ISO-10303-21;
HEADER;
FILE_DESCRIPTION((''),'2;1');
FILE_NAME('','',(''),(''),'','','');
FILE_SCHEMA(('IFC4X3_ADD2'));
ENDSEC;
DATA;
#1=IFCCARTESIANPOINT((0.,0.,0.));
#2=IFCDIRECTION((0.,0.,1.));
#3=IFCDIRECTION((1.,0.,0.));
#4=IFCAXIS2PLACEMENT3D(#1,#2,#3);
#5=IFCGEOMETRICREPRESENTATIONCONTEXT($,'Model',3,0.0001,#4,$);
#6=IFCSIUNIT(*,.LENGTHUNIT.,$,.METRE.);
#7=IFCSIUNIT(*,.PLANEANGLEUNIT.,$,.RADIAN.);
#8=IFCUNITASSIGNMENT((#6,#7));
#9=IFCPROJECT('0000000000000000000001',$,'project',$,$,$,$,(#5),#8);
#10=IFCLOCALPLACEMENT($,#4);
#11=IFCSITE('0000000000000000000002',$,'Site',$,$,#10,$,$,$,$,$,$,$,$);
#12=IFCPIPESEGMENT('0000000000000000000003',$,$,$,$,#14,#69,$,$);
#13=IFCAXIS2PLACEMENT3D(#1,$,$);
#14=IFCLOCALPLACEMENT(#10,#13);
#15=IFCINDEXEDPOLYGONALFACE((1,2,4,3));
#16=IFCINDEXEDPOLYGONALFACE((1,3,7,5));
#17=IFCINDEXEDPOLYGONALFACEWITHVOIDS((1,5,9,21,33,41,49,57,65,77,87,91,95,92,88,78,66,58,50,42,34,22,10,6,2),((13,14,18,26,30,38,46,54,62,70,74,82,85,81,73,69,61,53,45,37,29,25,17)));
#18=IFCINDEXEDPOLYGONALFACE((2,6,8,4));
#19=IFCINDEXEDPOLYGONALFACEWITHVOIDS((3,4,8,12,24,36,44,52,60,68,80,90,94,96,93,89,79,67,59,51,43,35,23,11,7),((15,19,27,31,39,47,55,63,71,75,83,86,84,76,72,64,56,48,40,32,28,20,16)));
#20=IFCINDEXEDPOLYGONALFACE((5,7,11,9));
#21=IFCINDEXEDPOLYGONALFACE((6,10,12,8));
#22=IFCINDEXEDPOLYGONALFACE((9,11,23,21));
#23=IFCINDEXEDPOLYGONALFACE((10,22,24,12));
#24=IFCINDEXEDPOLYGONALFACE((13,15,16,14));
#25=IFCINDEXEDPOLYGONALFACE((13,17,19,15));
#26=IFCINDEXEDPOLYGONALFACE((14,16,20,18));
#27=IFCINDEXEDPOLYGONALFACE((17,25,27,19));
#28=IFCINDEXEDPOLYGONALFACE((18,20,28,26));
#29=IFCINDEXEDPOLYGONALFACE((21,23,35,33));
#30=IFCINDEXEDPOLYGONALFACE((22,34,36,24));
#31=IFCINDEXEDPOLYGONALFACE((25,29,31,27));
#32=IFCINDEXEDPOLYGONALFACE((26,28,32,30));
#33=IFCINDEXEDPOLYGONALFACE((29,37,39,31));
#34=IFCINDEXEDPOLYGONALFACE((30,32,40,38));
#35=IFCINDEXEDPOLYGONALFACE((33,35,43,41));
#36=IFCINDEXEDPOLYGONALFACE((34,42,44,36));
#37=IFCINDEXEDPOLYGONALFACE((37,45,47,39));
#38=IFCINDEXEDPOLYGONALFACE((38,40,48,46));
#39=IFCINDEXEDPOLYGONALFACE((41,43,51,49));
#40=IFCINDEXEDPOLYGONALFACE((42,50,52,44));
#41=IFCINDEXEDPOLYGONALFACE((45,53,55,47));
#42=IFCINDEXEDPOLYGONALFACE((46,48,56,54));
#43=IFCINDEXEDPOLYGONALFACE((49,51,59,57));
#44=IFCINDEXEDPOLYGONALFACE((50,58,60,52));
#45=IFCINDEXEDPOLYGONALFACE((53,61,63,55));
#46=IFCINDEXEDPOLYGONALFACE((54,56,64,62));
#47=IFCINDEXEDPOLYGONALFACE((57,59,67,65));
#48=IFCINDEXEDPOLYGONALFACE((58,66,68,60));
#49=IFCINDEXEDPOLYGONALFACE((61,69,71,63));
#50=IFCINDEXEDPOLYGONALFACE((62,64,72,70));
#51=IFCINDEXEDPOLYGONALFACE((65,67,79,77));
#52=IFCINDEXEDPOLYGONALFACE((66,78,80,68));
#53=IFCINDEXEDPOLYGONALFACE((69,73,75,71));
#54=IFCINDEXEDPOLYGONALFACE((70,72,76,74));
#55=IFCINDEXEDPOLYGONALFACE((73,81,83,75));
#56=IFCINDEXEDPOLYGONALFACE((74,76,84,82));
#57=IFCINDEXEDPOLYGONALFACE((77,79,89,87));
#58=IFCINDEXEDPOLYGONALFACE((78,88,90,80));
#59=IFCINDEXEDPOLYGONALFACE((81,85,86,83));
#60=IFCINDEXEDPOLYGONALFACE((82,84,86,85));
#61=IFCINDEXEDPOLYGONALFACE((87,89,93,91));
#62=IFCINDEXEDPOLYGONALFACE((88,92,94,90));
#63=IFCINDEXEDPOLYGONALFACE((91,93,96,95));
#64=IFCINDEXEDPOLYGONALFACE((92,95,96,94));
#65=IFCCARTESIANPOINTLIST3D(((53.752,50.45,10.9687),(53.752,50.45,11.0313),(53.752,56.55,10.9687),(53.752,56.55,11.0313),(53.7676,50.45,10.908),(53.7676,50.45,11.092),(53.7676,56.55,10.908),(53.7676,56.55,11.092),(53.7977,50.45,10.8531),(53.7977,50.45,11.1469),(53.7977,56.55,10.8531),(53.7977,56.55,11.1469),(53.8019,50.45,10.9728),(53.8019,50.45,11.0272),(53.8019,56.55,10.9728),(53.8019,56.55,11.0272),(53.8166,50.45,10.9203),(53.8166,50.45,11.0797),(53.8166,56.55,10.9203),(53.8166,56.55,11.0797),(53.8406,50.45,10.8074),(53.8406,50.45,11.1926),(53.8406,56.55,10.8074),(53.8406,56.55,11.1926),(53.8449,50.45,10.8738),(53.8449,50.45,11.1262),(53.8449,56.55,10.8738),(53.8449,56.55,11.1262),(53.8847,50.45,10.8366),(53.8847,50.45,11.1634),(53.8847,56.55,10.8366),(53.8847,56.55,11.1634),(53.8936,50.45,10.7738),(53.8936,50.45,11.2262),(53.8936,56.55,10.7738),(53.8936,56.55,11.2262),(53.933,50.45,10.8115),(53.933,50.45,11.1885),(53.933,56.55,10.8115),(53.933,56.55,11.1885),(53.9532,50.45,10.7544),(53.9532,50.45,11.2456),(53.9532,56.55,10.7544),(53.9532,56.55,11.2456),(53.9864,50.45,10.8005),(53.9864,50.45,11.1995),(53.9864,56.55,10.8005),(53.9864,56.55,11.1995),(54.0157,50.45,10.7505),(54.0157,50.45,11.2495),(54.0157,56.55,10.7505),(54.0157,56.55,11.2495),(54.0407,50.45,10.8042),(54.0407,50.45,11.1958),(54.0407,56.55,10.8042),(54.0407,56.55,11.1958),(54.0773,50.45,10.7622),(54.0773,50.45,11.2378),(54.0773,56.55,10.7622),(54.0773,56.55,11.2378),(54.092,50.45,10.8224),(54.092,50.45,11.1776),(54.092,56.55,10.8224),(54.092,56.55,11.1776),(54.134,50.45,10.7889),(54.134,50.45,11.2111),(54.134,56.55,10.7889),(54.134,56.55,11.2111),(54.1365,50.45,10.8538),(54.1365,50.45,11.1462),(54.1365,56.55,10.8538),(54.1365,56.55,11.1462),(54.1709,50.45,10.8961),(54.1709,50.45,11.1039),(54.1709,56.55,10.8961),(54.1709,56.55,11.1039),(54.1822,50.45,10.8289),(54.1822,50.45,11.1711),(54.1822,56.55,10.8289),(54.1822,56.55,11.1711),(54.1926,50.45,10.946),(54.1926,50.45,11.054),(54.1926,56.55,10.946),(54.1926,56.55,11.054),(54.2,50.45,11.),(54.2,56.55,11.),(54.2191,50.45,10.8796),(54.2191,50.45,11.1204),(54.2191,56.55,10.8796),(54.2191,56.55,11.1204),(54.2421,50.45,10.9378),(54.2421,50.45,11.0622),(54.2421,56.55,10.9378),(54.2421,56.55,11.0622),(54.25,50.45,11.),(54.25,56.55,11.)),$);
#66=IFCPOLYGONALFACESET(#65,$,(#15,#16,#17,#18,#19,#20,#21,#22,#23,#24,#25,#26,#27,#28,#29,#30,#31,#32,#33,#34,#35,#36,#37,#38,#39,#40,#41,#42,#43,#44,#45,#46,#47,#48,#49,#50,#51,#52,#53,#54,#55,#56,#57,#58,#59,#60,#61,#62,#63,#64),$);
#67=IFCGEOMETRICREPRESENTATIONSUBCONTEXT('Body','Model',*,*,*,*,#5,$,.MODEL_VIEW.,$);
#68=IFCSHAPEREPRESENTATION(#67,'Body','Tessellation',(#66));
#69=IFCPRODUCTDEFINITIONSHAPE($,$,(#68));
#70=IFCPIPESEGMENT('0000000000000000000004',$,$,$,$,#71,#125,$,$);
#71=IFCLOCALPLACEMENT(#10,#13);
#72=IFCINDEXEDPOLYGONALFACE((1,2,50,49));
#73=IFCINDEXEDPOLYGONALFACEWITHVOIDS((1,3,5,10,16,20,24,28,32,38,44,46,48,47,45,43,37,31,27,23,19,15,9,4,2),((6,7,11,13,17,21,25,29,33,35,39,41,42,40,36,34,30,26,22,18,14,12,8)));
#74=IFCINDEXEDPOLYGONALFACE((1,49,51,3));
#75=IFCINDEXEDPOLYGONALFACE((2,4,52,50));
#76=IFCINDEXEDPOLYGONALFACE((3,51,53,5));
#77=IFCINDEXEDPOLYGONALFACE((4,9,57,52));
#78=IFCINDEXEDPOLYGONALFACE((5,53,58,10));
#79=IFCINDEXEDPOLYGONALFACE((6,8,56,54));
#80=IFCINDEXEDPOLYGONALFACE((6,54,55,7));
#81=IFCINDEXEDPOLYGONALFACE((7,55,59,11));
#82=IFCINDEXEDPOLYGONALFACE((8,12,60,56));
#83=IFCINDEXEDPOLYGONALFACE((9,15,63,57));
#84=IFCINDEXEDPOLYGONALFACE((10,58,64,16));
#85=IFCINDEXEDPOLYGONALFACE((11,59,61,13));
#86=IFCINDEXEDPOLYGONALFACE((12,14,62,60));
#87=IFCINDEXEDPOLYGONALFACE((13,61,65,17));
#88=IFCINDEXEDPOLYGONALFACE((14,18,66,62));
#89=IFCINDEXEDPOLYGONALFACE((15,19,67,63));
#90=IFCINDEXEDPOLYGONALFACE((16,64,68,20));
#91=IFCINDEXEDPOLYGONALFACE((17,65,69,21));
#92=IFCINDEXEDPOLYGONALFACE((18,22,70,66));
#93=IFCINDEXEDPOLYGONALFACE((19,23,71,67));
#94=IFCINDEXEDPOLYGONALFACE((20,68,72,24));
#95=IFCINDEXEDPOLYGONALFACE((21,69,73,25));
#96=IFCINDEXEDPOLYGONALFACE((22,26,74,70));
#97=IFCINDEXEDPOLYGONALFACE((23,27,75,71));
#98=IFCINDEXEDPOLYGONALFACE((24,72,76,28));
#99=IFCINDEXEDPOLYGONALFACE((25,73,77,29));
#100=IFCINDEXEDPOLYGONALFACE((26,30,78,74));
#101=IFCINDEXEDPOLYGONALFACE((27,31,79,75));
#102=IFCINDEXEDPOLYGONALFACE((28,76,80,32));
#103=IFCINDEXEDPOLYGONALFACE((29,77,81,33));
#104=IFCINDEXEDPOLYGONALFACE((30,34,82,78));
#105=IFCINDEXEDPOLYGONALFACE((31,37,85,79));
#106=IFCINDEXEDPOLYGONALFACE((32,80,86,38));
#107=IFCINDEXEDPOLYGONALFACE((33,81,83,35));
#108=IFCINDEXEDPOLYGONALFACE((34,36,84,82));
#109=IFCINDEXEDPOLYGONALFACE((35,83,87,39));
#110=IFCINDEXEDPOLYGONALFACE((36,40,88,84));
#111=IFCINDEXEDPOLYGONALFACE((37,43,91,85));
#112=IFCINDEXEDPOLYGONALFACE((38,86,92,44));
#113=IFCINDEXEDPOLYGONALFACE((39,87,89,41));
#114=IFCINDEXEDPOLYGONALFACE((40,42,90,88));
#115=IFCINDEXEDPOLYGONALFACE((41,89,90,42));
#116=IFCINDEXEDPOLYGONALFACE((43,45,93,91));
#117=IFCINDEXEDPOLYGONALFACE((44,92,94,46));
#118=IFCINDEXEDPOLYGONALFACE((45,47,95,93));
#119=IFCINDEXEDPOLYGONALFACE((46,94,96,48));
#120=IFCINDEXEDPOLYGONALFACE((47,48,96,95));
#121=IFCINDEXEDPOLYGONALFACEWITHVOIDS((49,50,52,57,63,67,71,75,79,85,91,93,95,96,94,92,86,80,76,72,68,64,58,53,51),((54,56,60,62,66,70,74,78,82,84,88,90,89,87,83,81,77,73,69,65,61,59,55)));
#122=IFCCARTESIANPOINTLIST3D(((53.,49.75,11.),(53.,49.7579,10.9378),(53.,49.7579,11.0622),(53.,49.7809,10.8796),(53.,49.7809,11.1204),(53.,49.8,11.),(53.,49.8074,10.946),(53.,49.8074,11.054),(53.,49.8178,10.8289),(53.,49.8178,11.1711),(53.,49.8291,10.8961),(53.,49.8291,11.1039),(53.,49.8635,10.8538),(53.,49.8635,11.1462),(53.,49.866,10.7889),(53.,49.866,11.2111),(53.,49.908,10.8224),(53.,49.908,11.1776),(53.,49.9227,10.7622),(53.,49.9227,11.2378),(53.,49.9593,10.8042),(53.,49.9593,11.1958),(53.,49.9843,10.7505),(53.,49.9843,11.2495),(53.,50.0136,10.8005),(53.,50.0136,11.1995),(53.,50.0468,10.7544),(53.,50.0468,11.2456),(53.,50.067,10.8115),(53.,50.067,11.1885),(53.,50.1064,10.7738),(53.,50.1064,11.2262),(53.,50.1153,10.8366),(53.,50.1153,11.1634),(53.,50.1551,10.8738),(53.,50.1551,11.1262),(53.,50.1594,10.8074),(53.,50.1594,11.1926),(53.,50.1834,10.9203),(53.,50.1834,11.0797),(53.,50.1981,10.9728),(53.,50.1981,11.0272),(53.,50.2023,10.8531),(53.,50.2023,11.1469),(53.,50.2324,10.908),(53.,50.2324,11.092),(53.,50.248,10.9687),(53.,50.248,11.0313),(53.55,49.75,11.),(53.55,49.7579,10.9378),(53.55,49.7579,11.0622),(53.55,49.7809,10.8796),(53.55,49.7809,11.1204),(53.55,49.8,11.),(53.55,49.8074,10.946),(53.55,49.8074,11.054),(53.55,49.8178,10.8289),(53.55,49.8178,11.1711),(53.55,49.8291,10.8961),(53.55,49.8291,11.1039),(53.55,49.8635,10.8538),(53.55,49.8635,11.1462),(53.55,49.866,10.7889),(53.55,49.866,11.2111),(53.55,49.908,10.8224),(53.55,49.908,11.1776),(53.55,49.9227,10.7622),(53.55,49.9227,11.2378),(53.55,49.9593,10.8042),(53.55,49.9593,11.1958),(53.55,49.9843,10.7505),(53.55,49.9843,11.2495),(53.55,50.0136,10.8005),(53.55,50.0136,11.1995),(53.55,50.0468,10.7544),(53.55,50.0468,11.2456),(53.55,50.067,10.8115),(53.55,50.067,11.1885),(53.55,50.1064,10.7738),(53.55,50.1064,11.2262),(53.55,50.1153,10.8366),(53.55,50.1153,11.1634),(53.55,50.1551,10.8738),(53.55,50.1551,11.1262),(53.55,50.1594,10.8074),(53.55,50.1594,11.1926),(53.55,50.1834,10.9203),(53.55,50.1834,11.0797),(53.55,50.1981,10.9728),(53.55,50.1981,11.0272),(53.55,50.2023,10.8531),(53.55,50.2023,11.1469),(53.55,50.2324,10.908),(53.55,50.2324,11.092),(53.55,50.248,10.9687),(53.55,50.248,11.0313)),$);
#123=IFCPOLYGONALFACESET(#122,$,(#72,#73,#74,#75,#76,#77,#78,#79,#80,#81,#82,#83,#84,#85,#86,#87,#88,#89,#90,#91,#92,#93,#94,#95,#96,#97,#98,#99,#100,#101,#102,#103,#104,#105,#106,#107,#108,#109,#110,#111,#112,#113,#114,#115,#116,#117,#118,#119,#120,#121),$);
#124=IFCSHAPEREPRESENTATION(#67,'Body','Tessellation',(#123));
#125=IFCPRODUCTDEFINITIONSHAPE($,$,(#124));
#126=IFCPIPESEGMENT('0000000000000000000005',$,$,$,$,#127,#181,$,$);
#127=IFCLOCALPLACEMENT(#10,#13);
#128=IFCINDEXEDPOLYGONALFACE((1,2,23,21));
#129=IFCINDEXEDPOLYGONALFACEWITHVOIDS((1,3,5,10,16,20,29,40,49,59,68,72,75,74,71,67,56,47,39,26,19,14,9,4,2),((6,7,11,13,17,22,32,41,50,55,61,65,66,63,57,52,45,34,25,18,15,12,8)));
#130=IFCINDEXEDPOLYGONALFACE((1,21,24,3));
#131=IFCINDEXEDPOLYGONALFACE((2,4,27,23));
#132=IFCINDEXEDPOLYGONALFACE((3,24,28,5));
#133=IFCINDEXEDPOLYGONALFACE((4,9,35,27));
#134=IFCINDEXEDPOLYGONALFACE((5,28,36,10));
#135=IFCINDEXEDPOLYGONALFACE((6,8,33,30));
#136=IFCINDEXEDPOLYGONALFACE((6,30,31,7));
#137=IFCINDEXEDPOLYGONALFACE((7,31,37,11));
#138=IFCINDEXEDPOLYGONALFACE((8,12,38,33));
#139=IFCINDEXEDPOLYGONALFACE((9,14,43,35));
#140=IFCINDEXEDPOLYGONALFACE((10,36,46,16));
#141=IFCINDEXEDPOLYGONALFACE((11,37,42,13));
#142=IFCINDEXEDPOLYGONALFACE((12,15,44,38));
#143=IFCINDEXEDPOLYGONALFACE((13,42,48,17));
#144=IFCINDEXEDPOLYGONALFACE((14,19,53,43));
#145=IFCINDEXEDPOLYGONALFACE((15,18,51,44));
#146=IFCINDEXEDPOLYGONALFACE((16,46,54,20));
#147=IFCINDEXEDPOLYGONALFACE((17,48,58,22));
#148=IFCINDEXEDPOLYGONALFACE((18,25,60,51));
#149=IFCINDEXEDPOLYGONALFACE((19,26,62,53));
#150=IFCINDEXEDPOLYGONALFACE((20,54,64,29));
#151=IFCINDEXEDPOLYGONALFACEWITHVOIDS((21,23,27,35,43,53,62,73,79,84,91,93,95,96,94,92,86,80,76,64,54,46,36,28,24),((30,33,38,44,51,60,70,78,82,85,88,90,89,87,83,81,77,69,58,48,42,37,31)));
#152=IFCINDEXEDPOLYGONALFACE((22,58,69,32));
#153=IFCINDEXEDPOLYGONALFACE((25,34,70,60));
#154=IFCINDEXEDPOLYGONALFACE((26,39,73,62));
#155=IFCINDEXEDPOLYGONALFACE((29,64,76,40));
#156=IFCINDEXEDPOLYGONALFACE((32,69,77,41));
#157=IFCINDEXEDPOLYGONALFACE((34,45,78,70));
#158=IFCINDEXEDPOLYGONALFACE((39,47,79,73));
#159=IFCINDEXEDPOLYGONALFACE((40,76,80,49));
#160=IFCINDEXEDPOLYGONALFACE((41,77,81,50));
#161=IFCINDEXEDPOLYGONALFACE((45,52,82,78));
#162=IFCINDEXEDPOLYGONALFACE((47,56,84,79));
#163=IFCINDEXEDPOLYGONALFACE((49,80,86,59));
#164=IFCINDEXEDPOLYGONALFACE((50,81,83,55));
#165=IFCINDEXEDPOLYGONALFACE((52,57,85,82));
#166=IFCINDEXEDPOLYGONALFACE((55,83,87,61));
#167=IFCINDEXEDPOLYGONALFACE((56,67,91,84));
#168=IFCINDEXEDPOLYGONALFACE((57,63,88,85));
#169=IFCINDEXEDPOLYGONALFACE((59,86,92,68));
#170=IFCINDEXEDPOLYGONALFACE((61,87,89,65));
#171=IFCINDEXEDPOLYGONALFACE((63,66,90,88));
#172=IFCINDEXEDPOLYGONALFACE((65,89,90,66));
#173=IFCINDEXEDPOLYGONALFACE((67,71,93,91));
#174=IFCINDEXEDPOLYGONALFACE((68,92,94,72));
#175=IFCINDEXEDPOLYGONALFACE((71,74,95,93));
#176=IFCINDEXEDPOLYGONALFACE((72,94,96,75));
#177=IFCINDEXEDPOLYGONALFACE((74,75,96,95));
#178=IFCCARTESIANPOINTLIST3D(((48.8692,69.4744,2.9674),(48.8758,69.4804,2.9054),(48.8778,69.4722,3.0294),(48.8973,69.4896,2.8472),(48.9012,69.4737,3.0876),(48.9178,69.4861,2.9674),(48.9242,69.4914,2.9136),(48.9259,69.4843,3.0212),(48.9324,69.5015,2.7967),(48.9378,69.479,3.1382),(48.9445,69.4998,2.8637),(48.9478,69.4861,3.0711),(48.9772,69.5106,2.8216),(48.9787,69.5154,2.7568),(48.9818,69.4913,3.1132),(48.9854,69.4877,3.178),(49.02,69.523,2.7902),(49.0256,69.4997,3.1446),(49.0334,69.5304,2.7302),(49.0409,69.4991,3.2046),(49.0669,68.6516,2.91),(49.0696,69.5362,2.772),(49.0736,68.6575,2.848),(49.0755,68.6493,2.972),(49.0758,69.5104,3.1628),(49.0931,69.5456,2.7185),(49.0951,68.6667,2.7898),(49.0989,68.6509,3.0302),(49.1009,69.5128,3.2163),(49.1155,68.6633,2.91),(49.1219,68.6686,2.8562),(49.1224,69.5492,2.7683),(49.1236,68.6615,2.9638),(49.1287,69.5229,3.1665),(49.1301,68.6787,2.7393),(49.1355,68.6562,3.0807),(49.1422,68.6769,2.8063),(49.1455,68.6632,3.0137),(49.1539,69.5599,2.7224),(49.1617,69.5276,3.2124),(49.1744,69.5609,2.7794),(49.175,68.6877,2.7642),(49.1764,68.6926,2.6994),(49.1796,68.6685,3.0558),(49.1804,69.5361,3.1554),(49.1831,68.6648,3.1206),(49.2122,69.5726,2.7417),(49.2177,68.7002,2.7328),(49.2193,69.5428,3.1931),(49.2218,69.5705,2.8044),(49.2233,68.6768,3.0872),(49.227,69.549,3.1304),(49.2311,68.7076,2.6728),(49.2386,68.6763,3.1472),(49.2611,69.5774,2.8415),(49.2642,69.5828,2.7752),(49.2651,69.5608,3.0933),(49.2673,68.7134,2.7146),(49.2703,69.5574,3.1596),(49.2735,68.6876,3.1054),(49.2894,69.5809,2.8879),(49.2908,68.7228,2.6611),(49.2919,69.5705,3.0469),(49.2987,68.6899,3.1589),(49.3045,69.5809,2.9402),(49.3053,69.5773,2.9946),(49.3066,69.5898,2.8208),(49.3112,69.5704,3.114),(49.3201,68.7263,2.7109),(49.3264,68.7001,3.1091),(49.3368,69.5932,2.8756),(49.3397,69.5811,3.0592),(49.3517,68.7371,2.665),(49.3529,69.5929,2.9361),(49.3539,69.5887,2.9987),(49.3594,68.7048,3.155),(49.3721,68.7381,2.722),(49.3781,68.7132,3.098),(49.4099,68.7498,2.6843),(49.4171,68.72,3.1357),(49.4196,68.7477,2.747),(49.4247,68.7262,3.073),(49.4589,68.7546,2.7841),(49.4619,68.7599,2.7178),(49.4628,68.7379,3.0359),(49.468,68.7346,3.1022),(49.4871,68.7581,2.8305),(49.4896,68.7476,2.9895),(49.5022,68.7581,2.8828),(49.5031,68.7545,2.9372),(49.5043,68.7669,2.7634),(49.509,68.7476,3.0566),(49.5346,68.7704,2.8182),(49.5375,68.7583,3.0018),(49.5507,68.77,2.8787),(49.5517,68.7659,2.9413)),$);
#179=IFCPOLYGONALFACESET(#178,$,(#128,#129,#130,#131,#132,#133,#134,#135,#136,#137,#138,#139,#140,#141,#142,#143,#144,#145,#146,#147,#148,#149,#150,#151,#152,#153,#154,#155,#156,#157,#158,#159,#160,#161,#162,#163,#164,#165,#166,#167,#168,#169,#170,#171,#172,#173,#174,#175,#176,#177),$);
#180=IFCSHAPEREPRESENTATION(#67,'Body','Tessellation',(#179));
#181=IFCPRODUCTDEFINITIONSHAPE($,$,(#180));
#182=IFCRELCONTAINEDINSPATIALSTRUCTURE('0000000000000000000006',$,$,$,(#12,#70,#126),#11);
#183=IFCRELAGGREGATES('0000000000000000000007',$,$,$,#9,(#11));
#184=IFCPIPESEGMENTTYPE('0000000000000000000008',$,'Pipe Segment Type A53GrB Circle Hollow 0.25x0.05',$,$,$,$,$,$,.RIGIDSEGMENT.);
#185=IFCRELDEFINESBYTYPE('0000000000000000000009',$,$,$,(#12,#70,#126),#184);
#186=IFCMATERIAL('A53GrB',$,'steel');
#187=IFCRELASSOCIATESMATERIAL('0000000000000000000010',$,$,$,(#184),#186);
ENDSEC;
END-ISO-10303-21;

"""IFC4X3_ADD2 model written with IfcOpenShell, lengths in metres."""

from ifc_helpers import new_model, si_unit, frame, origin_with_axes, place, context, subcontext, project, spatial, hollow_circle, extrude, material, material_profile, profile_set, type_object, element, save


model = new_model("IFC4X3_ADD2")

# Units and contexts
model_context = context("Model", 3, precision=0.0001, world=origin_with_axes())
body_context = subcontext(model_context, "Body", "Model", "MODEL_VIEW")
ifc_project = project(units=[si_unit("LENGTHUNIT", "METRE"), si_unit("PLANEANGLEUNIT", "RADIAN")], contexts=[model_context])

# Site
site_placement = place(None, origin_with_axes())
site = spatial("IfcSite", under=ifc_project, at=site_placement, Name="Site")

# Pipe segments
ifc_material = material(Name="A53GrB", Category="steel")
ifc_material_profile = material_profile(ifc_material, hollow_circle(Radius=0.25, WallThickness=0.05))
ifc_profile_set = profile_set([ifc_material_profile], Name="A53GrB steel Circle Hollow 0.25x0.05")
pipe_segment_type = type_object("IfcPipeSegmentType", Name="Pipe Segment Type A53GrB Circle Hollow 0.25x0.05", PredefinedType="RIGIDSEGMENT", material=ifc_profile_set)
pipe_segment_1_placement = place(None, frame((54.0, 56.55, 11.0), z_axis=(0.0, -1.0, 0.0), x_axis=(1.0, 0.0, 0.0)))
element("IfcPipeSegment", 1, at=pipe_segment_1_placement, inside=site, type_object=pipe_segment_type, context=body_context, shape_type="SweptSolid", body=[
    extrude(hollow_circle(Radius=0.25, WallThickness=0.05), origin_with_axes(), (0.0, 0.0, 1.0), 6.1),
])
pipe_segment_2_placement = place(None, frame((53.55, 50.0, 11.0), z_axis=(-1.0, 0.0, 0.0), x_axis=(0.0, -1.0, 0.0)))
element("IfcPipeSegment", 2, at=pipe_segment_2_placement, inside=site, type_object=pipe_segment_type, context=body_context, shape_type="SweptSolid", body=[
    extrude(hollow_circle(Radius=0.25, WallThickness=0.05), origin_with_axes(), (0.0, 0.0, 1.0), 0.55),
])
pipe_segment_3_placement = place(None, frame((49.31, 68.71, 2.91), z_axis=(-0.233122, 0.970089, 0.067681), x_axis=(-0.972319, -0.233658, 0.0)))
element("IfcPipeSegment", 3, at=pipe_segment_3_placement, inside=site, type_object=pipe_segment_type, context=body_context, shape_type="SweptSolid", body=[
    extrude(hollow_circle(Radius=0.25, WallThickness=0.05), origin_with_axes(), (0.0, 0.0, 1.0), 0.8482),
])

save(model, "model.ifc")
